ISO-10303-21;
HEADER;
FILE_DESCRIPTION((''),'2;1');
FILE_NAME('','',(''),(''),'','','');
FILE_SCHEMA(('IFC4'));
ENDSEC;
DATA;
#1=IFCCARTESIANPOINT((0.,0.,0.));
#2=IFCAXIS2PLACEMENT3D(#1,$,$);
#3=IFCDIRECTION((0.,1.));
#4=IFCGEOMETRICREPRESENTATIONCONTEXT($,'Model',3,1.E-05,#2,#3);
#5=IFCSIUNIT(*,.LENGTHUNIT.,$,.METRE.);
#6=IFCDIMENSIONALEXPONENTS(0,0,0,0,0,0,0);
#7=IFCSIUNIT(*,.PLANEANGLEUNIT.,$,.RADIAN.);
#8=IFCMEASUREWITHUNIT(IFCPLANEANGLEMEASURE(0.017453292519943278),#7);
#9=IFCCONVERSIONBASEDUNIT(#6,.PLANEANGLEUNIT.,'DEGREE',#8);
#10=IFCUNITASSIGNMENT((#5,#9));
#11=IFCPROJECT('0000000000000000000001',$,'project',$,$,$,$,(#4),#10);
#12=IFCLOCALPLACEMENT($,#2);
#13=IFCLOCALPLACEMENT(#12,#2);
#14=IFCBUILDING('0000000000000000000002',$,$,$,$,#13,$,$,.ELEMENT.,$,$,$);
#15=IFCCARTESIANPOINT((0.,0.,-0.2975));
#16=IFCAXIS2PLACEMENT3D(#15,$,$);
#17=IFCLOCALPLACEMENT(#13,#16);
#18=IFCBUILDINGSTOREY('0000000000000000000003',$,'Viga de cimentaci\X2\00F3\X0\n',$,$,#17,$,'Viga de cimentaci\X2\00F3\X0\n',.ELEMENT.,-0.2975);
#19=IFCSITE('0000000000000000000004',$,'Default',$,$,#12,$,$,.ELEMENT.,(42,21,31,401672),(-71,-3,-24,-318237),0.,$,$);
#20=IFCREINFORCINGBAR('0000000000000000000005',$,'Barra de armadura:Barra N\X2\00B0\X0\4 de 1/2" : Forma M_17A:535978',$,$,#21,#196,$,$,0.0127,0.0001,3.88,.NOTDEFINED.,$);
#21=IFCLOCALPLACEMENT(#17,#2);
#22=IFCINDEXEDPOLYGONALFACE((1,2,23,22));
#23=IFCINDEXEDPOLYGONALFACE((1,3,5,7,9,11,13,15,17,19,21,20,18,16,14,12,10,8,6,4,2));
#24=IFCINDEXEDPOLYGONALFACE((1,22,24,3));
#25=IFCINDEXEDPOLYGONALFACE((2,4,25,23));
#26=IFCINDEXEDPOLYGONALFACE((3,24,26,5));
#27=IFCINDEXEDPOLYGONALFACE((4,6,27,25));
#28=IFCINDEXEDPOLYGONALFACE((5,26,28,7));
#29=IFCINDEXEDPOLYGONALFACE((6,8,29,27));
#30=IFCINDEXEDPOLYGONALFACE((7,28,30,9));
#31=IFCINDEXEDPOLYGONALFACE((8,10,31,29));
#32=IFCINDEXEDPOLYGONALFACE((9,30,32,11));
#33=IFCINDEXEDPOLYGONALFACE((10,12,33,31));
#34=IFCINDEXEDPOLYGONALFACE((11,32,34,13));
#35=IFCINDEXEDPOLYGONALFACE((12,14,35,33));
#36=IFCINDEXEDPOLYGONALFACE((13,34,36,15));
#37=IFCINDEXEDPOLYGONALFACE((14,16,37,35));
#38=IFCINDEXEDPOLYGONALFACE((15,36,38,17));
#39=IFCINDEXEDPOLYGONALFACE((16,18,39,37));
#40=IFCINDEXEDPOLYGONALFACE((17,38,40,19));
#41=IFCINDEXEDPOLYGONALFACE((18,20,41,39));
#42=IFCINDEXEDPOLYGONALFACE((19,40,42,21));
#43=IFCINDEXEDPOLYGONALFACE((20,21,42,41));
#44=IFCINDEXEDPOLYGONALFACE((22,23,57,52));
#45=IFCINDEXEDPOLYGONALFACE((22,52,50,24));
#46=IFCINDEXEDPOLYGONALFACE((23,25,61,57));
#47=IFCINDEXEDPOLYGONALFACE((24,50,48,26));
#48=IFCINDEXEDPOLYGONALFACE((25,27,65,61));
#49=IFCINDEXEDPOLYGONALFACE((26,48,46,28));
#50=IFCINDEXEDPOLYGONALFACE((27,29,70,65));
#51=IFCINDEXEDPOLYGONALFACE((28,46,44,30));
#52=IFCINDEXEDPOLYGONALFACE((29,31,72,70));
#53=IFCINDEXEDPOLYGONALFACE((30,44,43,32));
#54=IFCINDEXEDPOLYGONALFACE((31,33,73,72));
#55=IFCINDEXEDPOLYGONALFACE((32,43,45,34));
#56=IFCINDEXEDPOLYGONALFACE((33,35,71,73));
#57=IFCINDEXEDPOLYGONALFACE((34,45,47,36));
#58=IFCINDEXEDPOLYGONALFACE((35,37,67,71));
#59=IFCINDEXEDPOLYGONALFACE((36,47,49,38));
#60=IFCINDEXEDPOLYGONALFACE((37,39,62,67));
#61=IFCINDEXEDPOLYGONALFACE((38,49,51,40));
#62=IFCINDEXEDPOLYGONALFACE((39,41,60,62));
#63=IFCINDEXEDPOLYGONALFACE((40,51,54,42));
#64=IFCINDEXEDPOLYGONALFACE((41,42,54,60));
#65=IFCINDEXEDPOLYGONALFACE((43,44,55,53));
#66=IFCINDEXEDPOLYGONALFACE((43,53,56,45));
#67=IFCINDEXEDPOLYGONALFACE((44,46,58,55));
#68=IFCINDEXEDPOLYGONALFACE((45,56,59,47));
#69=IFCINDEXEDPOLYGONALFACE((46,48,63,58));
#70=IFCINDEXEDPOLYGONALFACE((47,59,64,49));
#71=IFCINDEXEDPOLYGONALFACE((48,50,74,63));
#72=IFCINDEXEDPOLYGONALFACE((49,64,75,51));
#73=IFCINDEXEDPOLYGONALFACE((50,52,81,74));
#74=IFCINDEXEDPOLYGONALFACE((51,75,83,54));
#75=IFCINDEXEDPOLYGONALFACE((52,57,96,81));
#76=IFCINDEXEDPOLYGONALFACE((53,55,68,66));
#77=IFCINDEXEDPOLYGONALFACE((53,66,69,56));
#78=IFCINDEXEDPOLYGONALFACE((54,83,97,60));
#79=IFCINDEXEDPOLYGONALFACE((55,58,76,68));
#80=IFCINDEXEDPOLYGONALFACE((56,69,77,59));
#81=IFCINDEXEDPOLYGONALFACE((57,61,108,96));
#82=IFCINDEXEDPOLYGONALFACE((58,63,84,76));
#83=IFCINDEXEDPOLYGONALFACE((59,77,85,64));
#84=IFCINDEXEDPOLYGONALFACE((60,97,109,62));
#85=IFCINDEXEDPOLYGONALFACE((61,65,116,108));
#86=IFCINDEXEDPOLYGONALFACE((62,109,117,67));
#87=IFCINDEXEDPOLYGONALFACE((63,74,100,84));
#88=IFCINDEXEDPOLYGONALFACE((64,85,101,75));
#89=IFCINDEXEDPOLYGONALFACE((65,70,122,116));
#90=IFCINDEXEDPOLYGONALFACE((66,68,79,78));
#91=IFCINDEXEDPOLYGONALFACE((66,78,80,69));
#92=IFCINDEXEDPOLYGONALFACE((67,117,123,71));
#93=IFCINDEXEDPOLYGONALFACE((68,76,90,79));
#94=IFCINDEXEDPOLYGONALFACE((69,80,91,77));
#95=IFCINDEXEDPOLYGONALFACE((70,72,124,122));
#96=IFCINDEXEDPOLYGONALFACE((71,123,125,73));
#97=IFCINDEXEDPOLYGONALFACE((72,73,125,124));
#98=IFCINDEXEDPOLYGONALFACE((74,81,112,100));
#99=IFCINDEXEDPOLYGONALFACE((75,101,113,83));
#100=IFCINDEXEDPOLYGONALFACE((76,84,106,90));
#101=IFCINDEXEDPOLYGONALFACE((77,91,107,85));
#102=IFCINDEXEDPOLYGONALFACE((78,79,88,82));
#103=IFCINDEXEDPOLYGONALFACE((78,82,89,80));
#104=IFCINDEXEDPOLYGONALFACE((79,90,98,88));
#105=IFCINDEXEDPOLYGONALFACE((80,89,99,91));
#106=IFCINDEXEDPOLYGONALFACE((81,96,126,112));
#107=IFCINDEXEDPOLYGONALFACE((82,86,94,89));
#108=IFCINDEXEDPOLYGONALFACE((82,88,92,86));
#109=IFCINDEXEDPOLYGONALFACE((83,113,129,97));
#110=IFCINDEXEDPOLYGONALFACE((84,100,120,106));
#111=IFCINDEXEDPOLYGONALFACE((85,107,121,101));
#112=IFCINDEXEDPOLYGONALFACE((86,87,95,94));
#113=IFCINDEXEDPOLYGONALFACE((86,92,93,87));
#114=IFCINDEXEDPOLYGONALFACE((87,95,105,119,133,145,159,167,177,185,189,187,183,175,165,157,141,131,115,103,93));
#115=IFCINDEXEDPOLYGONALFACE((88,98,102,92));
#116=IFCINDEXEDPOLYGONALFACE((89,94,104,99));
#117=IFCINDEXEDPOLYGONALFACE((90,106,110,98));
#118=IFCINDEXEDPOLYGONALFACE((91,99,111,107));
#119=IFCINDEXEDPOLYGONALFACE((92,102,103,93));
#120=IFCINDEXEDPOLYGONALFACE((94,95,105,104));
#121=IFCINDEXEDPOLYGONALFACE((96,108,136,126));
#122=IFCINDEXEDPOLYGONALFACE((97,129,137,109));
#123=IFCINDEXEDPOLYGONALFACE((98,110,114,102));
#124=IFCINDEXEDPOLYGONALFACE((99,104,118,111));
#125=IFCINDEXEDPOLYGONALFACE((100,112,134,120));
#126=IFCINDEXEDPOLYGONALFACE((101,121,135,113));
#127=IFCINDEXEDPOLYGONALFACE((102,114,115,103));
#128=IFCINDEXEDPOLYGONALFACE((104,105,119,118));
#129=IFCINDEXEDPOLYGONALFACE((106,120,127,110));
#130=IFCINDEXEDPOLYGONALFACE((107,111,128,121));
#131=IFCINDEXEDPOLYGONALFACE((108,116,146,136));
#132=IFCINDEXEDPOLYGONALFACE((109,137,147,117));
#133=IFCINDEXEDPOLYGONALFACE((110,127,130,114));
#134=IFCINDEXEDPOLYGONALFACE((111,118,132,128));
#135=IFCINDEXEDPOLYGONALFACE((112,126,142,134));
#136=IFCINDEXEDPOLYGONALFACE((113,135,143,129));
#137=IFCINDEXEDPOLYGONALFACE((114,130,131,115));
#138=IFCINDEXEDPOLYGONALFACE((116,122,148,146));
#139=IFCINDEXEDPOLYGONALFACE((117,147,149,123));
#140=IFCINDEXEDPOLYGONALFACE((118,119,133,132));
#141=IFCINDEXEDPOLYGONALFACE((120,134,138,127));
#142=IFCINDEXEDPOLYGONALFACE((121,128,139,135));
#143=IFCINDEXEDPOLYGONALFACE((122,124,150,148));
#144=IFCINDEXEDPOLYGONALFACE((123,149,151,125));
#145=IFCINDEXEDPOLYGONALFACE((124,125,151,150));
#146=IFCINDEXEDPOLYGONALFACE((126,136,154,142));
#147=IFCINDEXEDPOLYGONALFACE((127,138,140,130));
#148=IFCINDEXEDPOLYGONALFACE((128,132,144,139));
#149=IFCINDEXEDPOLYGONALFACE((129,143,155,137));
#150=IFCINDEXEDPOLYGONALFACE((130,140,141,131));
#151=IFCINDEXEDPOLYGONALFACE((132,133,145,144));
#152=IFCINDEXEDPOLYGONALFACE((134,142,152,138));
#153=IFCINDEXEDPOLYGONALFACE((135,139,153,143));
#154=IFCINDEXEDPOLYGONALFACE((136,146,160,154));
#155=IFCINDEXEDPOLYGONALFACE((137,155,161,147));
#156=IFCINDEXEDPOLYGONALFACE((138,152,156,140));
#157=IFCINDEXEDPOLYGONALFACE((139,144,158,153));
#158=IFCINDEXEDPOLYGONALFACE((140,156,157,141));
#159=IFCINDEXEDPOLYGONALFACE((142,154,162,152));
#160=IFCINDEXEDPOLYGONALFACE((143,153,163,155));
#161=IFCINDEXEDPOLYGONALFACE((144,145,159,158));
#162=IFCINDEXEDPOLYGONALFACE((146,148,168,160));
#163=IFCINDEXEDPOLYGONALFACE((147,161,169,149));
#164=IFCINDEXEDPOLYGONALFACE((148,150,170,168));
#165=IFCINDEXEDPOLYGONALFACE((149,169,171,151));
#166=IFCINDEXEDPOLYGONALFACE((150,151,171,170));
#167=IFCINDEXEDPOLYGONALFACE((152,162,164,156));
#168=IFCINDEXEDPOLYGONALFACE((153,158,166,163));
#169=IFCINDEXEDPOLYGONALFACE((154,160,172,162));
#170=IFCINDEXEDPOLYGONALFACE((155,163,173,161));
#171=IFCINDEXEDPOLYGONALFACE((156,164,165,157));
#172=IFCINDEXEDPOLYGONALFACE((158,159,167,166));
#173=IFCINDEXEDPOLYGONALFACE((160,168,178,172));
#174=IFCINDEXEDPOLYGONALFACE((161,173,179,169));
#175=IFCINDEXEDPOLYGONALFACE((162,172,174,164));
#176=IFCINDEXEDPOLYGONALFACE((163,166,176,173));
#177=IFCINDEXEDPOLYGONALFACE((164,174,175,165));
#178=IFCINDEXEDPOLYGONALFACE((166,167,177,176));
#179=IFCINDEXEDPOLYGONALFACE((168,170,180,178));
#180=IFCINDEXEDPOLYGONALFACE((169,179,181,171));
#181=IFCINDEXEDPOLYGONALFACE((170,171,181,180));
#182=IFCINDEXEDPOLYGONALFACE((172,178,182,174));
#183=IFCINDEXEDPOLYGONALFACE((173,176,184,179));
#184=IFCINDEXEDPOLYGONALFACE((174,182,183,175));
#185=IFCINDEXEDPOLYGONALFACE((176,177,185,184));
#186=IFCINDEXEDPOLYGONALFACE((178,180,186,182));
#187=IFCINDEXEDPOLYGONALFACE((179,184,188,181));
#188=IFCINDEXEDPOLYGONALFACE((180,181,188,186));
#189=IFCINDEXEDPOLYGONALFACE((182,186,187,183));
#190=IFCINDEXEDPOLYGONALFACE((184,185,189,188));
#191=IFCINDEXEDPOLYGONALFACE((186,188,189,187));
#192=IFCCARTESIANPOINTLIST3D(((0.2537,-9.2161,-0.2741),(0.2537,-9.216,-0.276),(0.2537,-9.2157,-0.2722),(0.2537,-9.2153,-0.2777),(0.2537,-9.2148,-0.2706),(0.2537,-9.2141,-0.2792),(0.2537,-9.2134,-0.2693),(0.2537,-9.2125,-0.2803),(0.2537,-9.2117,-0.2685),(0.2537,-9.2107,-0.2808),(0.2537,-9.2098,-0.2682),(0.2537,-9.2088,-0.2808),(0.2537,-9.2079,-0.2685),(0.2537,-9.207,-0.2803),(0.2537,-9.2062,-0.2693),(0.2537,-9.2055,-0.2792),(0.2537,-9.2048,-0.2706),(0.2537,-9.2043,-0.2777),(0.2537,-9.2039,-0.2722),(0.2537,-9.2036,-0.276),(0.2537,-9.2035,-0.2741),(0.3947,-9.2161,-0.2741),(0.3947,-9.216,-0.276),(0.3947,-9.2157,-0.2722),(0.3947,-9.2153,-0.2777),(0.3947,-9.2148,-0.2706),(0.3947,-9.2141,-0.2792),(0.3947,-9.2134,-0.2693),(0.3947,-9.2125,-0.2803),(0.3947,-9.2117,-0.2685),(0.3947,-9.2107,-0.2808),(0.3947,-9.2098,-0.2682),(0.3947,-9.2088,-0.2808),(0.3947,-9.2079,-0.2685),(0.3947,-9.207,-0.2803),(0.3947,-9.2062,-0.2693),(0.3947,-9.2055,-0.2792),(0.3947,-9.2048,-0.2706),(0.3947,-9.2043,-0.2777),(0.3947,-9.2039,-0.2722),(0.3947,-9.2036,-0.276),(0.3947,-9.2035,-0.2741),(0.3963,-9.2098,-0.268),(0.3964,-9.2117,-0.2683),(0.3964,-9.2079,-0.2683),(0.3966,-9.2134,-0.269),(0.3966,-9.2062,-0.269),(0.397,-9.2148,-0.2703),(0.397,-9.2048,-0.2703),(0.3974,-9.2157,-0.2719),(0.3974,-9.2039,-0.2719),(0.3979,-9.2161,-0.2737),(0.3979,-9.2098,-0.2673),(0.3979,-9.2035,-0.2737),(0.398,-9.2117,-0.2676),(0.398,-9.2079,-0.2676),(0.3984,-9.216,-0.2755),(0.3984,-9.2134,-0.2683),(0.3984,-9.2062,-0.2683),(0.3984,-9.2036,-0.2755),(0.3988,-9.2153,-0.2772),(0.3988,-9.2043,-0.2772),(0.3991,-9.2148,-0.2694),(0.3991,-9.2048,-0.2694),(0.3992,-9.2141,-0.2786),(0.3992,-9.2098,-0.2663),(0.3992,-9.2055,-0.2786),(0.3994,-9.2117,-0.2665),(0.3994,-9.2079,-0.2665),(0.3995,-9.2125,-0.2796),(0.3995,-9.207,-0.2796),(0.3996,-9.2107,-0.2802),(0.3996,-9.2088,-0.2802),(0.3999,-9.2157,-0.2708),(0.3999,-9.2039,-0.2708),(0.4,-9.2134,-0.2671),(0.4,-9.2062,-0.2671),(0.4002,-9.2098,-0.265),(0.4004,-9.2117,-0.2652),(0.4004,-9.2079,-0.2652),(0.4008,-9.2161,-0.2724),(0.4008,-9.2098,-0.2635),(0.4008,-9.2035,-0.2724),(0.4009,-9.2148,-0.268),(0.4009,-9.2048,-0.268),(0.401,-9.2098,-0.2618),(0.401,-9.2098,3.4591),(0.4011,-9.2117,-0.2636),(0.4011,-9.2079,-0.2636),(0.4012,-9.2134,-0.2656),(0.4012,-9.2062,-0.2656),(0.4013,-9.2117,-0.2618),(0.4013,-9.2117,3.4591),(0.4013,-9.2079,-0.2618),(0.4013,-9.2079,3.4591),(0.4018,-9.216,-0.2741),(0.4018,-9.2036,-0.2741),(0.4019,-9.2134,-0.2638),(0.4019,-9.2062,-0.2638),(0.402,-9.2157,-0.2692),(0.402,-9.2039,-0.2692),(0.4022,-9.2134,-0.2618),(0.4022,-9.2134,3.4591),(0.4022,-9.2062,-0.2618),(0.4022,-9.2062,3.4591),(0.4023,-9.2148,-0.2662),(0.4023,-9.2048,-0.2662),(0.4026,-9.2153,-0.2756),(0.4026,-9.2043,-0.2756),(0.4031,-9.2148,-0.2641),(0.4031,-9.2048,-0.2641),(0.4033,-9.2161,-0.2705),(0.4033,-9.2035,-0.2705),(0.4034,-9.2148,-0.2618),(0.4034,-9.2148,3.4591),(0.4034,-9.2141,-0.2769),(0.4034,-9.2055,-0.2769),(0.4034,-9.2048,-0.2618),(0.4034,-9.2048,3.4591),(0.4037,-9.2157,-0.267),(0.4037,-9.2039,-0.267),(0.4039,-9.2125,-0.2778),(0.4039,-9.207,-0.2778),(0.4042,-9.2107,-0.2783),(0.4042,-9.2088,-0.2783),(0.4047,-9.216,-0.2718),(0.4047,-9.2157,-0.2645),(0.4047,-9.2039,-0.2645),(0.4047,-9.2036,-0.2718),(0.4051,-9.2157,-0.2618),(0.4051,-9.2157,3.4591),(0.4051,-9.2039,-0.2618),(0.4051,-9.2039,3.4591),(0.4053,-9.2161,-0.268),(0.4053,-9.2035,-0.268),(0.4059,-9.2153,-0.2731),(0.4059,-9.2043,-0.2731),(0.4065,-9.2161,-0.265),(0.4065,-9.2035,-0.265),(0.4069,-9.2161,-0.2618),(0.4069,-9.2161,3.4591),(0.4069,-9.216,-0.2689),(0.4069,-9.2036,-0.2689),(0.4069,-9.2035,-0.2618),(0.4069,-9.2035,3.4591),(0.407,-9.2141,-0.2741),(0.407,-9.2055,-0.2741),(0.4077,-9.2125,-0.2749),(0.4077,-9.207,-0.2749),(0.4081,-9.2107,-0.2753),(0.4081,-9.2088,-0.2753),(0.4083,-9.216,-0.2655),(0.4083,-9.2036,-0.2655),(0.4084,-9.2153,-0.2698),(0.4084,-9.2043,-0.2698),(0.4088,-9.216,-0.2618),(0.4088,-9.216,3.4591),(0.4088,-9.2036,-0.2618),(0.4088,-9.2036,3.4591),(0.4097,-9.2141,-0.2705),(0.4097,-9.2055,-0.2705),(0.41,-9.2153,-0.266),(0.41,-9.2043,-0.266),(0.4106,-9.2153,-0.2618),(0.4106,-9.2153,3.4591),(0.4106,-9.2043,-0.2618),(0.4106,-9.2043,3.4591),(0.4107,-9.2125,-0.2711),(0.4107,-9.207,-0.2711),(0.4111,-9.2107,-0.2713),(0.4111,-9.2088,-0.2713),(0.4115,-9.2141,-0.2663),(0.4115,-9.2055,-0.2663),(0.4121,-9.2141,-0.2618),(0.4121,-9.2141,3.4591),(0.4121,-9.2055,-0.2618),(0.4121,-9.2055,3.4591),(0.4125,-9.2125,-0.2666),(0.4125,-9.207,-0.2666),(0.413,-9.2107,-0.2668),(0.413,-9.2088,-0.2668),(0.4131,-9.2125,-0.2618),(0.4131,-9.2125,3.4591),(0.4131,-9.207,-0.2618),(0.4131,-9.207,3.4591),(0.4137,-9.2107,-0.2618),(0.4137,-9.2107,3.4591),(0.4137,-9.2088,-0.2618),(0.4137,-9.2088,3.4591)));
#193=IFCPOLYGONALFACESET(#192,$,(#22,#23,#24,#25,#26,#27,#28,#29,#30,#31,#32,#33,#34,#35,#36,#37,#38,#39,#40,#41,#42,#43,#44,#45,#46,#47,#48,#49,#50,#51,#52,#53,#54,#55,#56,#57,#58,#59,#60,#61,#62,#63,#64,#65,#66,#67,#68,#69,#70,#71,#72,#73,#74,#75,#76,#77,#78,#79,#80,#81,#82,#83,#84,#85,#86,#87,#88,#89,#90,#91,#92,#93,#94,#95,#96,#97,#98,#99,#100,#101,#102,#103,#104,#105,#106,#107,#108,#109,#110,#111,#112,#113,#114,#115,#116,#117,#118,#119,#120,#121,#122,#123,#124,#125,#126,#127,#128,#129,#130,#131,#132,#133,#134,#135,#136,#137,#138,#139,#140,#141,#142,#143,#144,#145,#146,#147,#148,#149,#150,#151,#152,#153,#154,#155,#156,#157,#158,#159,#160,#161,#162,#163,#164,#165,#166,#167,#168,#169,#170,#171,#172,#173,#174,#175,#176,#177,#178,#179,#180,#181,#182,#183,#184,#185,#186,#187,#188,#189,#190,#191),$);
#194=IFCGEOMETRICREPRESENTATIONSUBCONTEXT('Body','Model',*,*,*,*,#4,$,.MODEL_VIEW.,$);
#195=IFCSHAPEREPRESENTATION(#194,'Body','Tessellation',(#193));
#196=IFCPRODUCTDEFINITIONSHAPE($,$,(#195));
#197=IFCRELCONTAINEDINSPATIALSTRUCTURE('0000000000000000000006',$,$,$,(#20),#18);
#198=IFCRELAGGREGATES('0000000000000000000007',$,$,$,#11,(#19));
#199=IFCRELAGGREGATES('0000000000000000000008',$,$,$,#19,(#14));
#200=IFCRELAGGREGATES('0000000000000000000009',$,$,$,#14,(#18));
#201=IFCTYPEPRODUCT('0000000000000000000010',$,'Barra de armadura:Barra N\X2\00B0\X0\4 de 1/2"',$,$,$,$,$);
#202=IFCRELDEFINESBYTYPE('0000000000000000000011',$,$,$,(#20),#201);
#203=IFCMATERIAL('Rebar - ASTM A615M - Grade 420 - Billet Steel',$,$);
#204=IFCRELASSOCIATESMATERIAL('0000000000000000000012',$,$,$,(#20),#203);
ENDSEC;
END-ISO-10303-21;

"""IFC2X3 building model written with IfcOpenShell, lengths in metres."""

from ifc_helpers import new_model, entity, si_unit, converted_unit, direction, frame, origin, place, context, subcontext, project, spatial, material, type_object, element, save


model = new_model("IFC2X3")

# Units and contexts
model_context = context("Model", 3, precision=1e-05, world=origin(), true_north=direction((0.0, 1.0)))
body_context = subcontext(model_context, "Body", "Model", "MODEL_VIEW")
ifc_project = project(units=[si_unit("LENGTHUNIT", "METRE"), converted_unit("PLANEANGLEUNIT", "DEGREE", entity("IfcPlaneAngleMeasure", 0.017453292519943278), si_unit("PLANEANGLEUNIT", "RADIAN"), dimensions=[0, 0, 0, 0, 0, 0, 0])], contexts=[model_context])

# Site, building, storey
site_placement = place(None, origin())
site = spatial("IfcSite", under=ifc_project, at=site_placement, Name="Default", CompositionType="ELEMENT", RefLatitude=(42, 21, 31, 401672), RefLongitude=(-71, -3, -24, -318237), RefElevation=0.0)
building_placement = place(site_placement, origin())
building = spatial("IfcBuilding", under=site, at=building_placement, CompositionType="ELEMENT")
storey_placement = place(building_placement, frame((0.0, 0.0, -0.2975)))
storey = spatial("IfcBuildingStorey", under=building, at=storey_placement, Name="Viga de cimentación", LongName="Viga de cimentación", CompositionType="ELEMENT", Elevation=-0.2975)

# Reinforcing bar
ifc_material = material(Name="Rebar - ASTM A615M - Grade 420 - Billet Steel")
type_product_1 = type_object("IfcTypeProduct", Name="Barra de armadura:Barra N°4 de 1/2\"")
reinforcing_bar_1_placement = place(storey_placement, origin())
element("IfcReinforcingBar", 1, at=reinforcing_bar_1_placement, inside=storey, type_object=type_product_1, material=ifc_material, Name="Barra de armadura:Barra N°4 de 1/2\" : Forma M_17A:535978", BarLength=3.88, BarRole="NOTDEFINED", CrossSectionArea=0.0001, NominalDiameter=0.0127, context=body_context, shape_type="AdvancedSweptSolid", body=[
    entity("IfcSweptDiskSolid", entity("IfcCompositeCurve", [entity("IfcCompositeCurveSegment", "CONTINUOUS", True, entity("IfcPolyline", [entity("IfcCartesianPoint", [0.4074, -9.2098, 3.4591]), entity("IfcCartesianPoint", [0.4074, -9.2098, -0.2618])])), entity("IfcCompositeCurveSegment", "CONTINUOUS", True, entity("IfcTrimmedCurve", entity("IfcCircle", entity("IfcAxis2Placement3D", entity("IfcCartesianPoint", [0.3947, -9.2098, -0.2618]), entity("IfcDirection", [0.0, 1.0, 0.0]), entity("IfcDirection", [0.0, 0.0, -1.0])), 0.0127), [entity("IfcParameterValue", 270.0)], [entity("IfcParameterValue", 360.0)], True, "PARAMETER")), entity("IfcCompositeCurveSegment", "CONTINUOUS", True, entity("IfcPolyline", [entity("IfcCartesianPoint", [0.3947, -9.2098, -0.2745]), entity("IfcCartesianPoint", [0.2537, -9.2098, -0.2745])]))], False), 0.0063, None, 0.0, 92.0),
])

save(model, "model.ifc")
